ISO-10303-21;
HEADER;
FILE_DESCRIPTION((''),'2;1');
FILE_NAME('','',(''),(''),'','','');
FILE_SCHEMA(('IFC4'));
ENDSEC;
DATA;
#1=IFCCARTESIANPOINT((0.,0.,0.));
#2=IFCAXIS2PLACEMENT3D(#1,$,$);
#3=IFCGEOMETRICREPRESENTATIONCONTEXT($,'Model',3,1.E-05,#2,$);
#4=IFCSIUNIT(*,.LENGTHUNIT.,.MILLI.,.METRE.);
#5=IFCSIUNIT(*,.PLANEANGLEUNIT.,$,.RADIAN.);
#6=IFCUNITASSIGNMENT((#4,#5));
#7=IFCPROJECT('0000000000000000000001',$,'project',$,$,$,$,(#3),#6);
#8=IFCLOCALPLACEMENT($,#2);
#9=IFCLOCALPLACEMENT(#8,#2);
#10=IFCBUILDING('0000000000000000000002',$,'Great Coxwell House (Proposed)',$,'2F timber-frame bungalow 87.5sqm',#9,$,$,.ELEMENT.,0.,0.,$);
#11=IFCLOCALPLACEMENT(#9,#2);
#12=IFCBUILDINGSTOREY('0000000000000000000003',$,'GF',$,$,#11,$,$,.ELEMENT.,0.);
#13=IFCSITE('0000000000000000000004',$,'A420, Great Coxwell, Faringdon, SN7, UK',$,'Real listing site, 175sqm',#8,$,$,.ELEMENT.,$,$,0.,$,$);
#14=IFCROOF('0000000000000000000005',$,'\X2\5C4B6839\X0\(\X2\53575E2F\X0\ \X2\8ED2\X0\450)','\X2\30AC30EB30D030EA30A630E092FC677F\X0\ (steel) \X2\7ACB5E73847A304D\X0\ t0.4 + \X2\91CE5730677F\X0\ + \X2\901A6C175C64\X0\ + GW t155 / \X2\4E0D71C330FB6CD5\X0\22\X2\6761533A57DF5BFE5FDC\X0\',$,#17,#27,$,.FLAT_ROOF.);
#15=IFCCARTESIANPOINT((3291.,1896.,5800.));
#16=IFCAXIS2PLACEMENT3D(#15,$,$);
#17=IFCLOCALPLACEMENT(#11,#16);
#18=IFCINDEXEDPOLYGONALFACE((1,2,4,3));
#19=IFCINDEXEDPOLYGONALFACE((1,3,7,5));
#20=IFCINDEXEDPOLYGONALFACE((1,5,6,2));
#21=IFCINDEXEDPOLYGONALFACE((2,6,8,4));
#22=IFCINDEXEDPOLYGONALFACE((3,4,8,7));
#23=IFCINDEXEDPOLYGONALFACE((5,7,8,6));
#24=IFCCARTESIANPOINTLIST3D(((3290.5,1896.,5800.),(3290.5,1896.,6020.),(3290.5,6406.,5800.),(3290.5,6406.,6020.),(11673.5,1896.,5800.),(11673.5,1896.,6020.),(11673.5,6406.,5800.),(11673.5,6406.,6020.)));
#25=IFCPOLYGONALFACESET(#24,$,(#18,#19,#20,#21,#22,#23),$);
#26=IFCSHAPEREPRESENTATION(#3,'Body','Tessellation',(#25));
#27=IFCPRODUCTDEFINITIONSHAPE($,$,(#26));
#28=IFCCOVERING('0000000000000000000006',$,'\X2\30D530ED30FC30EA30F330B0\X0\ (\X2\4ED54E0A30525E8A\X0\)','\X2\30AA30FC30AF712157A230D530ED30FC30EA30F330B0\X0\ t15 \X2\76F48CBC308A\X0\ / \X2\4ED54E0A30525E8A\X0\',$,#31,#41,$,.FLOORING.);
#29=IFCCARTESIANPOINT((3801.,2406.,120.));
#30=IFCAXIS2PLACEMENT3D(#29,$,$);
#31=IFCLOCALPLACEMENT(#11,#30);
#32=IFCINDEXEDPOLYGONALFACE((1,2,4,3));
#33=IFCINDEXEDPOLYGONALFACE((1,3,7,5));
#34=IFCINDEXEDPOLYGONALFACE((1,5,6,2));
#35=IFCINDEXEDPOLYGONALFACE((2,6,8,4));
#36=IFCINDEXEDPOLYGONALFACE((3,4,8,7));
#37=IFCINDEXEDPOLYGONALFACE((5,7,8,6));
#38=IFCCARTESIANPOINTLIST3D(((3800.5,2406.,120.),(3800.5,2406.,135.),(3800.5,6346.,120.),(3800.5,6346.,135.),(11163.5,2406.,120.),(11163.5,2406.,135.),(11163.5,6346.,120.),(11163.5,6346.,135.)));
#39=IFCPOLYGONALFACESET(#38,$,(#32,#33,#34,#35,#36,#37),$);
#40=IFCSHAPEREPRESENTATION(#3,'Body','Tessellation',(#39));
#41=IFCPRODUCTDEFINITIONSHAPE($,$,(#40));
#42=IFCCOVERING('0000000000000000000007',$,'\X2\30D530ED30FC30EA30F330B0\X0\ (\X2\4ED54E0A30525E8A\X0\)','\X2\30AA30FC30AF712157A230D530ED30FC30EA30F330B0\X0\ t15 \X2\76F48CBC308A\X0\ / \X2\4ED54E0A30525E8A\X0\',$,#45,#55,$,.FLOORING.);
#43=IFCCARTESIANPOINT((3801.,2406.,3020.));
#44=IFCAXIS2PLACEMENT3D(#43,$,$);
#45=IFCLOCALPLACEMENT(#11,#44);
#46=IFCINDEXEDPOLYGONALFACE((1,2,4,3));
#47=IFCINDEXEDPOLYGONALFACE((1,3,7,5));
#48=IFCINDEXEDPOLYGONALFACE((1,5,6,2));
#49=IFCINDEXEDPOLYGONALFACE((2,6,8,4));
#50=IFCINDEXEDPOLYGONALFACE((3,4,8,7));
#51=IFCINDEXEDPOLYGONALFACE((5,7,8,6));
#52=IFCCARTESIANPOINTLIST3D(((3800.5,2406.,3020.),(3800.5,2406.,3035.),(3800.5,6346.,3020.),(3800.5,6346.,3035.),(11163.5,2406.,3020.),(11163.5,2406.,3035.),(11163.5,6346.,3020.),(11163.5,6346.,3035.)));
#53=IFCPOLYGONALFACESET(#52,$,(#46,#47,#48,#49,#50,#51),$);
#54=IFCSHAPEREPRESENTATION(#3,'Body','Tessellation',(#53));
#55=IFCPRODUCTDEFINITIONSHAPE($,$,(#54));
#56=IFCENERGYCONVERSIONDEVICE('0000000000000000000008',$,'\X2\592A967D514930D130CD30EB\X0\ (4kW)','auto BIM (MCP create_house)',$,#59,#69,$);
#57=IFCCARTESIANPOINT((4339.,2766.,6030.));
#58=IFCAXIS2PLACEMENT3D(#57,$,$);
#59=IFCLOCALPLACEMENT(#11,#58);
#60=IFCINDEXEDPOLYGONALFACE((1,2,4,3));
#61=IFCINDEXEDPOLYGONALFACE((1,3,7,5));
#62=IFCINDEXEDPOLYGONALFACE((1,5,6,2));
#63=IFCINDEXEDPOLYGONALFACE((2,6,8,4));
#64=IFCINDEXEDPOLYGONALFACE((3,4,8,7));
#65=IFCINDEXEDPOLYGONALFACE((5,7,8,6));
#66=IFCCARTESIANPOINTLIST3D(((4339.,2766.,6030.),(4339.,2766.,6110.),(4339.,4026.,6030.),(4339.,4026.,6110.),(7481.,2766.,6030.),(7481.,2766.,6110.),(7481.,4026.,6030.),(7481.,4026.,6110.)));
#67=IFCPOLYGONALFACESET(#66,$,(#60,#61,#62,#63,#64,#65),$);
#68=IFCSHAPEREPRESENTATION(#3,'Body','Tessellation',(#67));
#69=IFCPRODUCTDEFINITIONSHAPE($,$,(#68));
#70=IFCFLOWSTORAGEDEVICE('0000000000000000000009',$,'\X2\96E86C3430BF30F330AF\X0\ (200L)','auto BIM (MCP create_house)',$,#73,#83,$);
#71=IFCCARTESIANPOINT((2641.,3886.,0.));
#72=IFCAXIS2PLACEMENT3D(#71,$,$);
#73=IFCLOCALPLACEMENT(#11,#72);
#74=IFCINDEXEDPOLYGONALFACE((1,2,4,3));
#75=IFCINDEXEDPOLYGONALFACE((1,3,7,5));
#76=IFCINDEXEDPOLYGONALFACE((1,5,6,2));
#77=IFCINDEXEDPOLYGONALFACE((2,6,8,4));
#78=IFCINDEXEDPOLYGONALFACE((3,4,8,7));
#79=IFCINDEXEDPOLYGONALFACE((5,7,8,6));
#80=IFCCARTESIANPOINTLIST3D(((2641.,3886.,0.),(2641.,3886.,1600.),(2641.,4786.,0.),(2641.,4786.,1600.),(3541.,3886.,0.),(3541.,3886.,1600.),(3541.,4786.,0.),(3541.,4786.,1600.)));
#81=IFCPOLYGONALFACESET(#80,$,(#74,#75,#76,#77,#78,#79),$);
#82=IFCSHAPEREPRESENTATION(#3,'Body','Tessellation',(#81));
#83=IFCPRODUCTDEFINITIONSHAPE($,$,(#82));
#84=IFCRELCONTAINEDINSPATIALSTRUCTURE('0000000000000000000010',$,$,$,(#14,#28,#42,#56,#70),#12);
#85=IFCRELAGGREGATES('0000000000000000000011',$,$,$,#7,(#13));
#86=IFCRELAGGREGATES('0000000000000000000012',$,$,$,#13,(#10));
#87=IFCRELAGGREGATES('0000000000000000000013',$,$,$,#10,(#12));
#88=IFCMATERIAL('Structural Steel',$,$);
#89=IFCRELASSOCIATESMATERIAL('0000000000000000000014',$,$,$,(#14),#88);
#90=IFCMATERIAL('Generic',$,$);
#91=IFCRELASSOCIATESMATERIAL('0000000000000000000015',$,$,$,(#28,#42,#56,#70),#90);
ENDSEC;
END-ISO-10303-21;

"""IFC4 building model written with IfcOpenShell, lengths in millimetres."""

from ifc_helpers import new_model, si_unit, frame, frame_2d, origin, place, context, project, spatial, rectangle, extrude, material, element, save


model = new_model("IFC4")

# Units and contexts
model_context = context("Model", 3, precision=1e-05, world=origin())
ifc_project = project(units=[si_unit("LENGTHUNIT", "METRE", prefix="MILLI"), si_unit("PLANEANGLEUNIT", "RADIAN")], contexts=[model_context])

# Site, building, storey
site_placement = place(None, origin())
site = spatial("IfcSite", under=ifc_project, at=site_placement, Name="A420, Great Coxwell, Faringdon, SN7, UK", ObjectType="Real listing site, 175sqm", CompositionType="ELEMENT", RefElevation=0.0)
building_placement = place(site_placement, origin())
building = spatial("IfcBuilding", under=site, at=building_placement, Name="Great Coxwell House (Proposed)", ObjectType="2F timber-frame bungalow 87.5sqm", CompositionType="ELEMENT", ElevationOfRefHeight=0.0, ElevationOfTerrain=0.0)
storey_placement = place(building_placement, origin())
storey = spatial("IfcBuildingStorey", under=building, at=storey_placement, Name="GF", CompositionType="ELEMENT", Elevation=0.0)

# Roof
ifc_material_1 = material(Name="Structural Steel")
for number, where, name in (
    (1, (3291.0, 1896.0, 5800.0), "屋根(南帯 軒450)"),
):
    element("IfcRoof", number, at=place(storey_placement, frame(where)), inside=storey, material=ifc_material_1, Name=name, Description="ガルバリウム鋼板 (steel) 立平葺き t0.4 + 野地板 + 通気層 + GW t155 / 不燃・法22条区域対応", PredefinedType="FLAT_ROOF", context=model_context, shape_type="SweptSolid", body=[
        extrude(rectangle(XDim=8383.0, YDim=4510.0, at=frame_2d((4191.0, 2255.0))), frame((3291.0, 1896.0, 5800.0)), (0.0, 0.0, 1.0), 220.0),
    ])

# Coverings
ifc_material_2 = material(Name="Generic")
covering_1_placement = place(storey_placement, frame((3801.0, 2406.0, 120.0)))
element("IfcCovering", 2, at=covering_1_placement, inside=storey, material=ifc_material_2, Name="フローリング (仕上げ床)", Description="オーク無垢フローリング t15 直貼り / 仕上げ床", PredefinedType="FLOORING", context=model_context, shape_type="SweptSolid", body=[
    extrude(rectangle(XDim=7363.0, YDim=3940.0, at=frame_2d((3681.0, 1970.0))), frame((3801.0, 2406.0, 120.0)), (0.0, 0.0, 1.0), 15.0),
])
covering_2_placement = place(storey_placement, frame((3801.0, 2406.0, 3020.0)))
element("IfcCovering", 3, at=covering_2_placement, inside=storey, material=ifc_material_2, Name="フローリング (仕上げ床)", Description="オーク無垢フローリング t15 直貼り / 仕上げ床", PredefinedType="FLOORING", context=model_context, shape_type="SweptSolid", body=[
    extrude(rectangle(XDim=7363.0, YDim=3940.0, at=frame_2d((3681.0, 1970.0))), frame((3801.0, 2406.0, 3020.0)), (0.0, 0.0, 1.0), 15.0),
])

# Energy conversion device
energy_conversion_device_placement = place(storey_placement, frame((4339.0, 2766.0, 6030.0)))
element("IfcEnergyConversionDevice", 4, at=energy_conversion_device_placement, inside=storey, material=ifc_material_2, Name="太陽光パネル (4kW)", Description="auto BIM (MCP create_house)", context=model_context, shape_type="SweptSolid", body=[
    extrude(rectangle(XDim=3142.0, YDim=1260.0, at=frame_2d((1571.0, 630.0))), frame((4339.0, 2766.0, 6030.0)), (0.0, 0.0, 1.0), 80.0),
])

# Flow storage device
flow_storage_device_placement = place(storey_placement, frame((2641.0, 3886.0, 0.0)))
element("IfcFlowStorageDevice", 5, at=flow_storage_device_placement, inside=storey, material=ifc_material_2, Name="雨水タンク (200L)", Description="auto BIM (MCP create_house)", context=model_context, shape_type="SweptSolid", body=[
    extrude(rectangle(XDim=900.0, YDim=900.0, at=frame_2d((450.0, 450.0))), frame((2641.0, 3886.0, 0.0)), (0.0, 0.0, 1.0), 1600.0),
])

save(model, "model.ifc")
